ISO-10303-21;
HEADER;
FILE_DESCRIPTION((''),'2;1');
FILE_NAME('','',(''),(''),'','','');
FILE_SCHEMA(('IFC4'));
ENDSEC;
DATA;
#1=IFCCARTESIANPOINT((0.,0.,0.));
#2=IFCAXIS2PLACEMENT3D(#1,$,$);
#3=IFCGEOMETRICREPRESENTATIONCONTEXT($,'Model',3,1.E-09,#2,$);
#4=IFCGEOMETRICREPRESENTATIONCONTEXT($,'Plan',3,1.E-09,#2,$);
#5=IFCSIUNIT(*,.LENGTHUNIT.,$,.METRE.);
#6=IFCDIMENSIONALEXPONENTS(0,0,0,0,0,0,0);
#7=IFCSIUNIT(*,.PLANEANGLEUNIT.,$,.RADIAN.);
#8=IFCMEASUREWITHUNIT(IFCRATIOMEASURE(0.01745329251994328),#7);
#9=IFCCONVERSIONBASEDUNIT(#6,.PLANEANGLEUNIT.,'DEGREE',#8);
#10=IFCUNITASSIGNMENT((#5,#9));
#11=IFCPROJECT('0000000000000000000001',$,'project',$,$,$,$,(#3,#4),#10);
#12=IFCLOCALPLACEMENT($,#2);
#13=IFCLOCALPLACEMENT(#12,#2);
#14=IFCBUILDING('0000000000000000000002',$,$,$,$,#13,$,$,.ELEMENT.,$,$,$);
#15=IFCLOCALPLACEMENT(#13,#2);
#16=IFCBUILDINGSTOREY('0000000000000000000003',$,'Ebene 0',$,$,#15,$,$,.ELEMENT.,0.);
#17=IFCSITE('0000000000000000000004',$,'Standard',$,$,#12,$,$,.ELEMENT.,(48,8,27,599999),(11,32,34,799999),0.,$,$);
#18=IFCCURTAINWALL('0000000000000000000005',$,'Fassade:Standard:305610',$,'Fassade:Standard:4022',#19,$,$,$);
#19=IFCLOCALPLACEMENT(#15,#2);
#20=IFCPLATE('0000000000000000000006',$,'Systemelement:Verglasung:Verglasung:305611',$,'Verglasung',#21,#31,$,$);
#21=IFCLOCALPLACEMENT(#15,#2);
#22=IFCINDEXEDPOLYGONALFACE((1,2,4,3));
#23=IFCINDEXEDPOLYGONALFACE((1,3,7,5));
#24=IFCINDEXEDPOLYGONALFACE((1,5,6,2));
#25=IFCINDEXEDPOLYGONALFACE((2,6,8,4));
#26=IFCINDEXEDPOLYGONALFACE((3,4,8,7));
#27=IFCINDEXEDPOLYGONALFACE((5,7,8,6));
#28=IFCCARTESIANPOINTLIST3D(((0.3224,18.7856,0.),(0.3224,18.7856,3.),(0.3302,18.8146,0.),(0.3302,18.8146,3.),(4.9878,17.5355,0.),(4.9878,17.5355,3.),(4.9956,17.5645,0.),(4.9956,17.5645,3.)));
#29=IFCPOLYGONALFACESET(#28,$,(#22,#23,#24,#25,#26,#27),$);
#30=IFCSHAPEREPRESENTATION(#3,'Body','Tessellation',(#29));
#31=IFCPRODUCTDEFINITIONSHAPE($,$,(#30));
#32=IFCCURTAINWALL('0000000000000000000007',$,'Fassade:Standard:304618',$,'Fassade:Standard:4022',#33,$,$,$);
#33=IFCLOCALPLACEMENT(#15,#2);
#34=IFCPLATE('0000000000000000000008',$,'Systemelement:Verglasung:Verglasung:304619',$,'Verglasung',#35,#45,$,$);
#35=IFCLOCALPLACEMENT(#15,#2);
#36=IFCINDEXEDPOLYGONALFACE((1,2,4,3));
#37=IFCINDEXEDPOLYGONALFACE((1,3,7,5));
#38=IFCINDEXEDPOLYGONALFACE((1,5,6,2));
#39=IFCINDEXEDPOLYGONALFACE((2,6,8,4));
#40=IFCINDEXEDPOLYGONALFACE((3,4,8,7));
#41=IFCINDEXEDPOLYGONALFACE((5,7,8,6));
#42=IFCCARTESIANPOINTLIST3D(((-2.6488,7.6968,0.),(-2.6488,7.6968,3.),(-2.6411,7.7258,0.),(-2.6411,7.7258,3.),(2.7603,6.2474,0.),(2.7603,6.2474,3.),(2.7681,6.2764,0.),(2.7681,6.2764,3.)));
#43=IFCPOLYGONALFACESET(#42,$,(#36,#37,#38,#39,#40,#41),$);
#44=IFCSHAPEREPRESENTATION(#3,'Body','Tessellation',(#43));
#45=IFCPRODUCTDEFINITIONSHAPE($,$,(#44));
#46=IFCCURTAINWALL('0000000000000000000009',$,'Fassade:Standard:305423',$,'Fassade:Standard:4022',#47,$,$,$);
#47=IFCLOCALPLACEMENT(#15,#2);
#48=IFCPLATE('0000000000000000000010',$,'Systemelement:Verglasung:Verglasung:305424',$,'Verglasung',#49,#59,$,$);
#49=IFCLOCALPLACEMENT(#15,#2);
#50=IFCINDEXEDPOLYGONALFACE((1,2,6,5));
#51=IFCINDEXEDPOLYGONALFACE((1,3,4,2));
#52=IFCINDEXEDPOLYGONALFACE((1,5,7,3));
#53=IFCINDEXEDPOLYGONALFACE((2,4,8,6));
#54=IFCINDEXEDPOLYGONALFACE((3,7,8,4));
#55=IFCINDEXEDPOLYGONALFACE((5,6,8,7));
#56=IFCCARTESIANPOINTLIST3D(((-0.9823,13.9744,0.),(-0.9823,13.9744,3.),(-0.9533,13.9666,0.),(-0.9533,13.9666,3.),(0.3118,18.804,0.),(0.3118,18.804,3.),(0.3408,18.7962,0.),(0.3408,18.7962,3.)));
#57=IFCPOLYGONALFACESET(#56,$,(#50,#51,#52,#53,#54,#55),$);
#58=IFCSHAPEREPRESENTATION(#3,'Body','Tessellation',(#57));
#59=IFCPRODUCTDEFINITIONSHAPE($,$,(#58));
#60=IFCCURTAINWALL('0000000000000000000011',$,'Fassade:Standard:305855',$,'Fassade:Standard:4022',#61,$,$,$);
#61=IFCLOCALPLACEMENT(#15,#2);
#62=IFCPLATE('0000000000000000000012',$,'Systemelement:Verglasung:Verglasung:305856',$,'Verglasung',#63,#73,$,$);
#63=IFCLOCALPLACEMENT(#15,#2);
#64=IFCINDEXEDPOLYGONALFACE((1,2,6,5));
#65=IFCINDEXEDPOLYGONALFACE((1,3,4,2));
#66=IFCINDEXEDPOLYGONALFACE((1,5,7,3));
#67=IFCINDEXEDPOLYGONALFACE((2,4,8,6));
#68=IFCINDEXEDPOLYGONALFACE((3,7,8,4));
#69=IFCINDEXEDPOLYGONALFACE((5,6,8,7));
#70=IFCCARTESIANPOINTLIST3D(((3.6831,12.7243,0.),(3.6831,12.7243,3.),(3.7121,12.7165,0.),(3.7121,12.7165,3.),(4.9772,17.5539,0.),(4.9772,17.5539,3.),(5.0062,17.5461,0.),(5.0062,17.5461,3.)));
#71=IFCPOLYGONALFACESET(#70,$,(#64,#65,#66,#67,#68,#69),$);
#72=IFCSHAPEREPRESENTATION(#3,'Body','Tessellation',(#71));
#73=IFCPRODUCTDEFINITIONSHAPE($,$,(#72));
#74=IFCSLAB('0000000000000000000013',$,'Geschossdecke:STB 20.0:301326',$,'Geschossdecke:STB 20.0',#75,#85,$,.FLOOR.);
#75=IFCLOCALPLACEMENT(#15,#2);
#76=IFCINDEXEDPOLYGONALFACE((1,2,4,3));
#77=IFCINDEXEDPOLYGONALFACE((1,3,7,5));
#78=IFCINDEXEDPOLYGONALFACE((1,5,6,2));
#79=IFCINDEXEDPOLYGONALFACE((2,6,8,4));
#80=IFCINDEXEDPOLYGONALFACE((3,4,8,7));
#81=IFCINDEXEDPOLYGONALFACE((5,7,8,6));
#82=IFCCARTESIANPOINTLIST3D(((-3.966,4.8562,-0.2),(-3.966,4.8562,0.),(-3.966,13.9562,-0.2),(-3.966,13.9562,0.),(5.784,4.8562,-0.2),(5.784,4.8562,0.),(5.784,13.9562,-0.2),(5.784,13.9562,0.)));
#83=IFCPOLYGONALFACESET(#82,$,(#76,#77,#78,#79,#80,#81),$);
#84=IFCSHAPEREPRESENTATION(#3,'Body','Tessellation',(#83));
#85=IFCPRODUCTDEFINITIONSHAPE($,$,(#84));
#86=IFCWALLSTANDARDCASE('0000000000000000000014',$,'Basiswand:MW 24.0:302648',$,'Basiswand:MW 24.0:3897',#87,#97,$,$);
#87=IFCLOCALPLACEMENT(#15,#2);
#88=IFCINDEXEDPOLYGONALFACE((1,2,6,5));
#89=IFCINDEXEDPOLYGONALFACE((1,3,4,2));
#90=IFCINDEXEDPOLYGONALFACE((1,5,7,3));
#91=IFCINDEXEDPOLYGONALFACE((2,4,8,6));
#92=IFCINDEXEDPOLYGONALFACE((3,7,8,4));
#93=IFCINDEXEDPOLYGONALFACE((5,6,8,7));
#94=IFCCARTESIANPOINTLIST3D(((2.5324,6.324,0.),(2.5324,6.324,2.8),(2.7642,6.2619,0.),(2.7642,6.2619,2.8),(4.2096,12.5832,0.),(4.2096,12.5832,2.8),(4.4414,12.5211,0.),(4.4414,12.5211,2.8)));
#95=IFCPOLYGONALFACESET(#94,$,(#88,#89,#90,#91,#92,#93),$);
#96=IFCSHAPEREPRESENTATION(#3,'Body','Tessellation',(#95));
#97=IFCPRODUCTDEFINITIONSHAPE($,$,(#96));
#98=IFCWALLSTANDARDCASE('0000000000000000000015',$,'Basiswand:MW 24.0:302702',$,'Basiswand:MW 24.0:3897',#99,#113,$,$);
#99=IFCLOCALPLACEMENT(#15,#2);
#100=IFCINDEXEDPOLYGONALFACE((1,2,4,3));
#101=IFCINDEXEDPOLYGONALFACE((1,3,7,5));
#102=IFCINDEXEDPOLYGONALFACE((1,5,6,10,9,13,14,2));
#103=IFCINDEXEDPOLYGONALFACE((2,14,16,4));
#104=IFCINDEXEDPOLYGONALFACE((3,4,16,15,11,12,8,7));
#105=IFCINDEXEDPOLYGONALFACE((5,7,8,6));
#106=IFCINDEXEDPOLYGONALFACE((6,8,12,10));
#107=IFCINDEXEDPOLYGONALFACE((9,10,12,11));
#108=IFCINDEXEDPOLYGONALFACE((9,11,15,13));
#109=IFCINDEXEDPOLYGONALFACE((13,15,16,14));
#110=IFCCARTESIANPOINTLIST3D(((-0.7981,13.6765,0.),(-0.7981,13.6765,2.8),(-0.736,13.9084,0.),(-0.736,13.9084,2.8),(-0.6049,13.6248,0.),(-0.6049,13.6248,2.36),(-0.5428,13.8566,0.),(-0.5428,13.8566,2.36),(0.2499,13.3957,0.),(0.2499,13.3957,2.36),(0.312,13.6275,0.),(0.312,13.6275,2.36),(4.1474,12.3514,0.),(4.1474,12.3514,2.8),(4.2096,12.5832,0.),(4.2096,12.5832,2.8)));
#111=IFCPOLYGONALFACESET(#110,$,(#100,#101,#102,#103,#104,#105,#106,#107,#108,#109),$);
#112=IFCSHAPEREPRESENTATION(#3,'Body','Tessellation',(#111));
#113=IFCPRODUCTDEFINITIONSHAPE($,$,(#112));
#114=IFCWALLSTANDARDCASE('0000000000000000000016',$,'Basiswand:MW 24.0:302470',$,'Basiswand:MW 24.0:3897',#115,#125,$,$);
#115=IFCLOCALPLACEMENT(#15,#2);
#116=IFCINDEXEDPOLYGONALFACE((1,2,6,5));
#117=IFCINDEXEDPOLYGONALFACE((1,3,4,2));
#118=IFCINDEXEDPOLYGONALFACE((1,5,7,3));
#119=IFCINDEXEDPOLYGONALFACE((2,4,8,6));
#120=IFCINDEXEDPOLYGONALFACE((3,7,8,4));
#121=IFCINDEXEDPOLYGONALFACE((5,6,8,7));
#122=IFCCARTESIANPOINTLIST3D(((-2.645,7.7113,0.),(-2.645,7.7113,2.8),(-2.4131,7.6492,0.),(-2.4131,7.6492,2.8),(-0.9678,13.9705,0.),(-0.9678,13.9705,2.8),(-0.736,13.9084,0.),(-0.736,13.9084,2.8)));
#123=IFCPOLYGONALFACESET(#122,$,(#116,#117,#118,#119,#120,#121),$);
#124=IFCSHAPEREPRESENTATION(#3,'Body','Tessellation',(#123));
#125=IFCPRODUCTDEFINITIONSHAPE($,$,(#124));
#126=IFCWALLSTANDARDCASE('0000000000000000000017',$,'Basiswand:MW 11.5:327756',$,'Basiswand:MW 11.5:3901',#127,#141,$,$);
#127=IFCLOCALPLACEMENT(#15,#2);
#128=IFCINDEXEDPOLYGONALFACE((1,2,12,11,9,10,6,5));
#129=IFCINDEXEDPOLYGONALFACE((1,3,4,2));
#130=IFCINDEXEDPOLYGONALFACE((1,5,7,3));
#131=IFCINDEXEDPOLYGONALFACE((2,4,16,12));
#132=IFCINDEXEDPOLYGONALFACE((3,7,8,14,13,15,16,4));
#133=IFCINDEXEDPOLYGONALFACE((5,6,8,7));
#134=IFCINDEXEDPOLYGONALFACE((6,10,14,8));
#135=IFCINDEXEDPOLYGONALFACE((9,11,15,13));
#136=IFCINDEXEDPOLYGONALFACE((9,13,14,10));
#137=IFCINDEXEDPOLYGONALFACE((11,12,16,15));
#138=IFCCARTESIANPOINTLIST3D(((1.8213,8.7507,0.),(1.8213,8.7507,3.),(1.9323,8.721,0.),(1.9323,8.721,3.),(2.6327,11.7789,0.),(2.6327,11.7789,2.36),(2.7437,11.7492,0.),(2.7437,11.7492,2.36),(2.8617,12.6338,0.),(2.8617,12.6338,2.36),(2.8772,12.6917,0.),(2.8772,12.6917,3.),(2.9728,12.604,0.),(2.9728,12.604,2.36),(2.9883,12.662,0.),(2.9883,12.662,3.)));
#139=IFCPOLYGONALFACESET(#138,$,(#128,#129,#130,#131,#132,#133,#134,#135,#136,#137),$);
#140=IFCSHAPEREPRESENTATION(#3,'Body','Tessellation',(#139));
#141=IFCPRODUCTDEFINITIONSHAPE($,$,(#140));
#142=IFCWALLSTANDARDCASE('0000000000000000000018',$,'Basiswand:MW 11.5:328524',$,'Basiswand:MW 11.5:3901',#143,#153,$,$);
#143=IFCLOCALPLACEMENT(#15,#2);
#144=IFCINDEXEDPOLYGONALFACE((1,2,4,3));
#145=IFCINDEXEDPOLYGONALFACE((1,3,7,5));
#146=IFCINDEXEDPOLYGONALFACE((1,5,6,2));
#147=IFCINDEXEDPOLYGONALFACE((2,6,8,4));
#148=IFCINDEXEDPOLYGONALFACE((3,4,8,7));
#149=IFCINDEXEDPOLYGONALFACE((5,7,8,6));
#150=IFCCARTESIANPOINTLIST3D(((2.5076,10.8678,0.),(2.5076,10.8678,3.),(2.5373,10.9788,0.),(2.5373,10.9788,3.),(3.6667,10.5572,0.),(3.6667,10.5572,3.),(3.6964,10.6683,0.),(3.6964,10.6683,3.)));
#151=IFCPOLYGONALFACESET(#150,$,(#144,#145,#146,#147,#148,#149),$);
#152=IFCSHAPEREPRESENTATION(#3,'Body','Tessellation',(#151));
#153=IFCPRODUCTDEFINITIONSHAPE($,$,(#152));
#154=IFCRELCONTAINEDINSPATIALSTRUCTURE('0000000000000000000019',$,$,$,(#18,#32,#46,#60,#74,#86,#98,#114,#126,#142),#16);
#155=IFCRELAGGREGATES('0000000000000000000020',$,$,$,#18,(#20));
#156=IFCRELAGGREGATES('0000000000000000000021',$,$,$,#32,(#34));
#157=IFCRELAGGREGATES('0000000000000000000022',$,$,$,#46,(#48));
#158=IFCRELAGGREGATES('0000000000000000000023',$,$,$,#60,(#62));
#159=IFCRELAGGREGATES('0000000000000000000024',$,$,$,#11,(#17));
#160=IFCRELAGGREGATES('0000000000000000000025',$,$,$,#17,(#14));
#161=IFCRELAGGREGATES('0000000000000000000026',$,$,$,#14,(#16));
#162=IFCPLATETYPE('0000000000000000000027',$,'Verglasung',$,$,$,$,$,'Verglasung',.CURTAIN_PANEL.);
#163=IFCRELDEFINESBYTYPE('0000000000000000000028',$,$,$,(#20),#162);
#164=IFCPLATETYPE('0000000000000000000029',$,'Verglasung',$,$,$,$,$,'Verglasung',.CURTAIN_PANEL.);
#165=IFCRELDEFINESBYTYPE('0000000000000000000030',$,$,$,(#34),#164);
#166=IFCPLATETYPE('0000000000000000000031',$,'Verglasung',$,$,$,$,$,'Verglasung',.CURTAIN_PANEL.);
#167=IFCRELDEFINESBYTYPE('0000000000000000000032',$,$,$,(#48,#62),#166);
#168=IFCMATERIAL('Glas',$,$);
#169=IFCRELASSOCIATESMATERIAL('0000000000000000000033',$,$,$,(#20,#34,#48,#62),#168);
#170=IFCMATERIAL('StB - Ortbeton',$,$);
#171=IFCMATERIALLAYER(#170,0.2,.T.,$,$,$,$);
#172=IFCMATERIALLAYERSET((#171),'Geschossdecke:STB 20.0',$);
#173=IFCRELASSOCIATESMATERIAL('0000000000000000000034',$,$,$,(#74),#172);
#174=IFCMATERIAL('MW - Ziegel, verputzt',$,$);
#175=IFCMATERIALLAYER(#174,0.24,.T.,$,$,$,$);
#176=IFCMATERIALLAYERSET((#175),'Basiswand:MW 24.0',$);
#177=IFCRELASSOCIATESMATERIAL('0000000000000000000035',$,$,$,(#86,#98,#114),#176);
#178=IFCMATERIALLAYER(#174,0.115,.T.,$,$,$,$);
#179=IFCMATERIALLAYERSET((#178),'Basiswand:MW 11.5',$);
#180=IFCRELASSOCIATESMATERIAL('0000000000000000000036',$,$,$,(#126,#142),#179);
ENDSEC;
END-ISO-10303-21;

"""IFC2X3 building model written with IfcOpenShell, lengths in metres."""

from ifc_helpers import new_model, entity, si_unit, converted_unit, frame, frame_2d, origin, origin_2d_with_axis, place, context, project, spatial, polyline, rectangle, extrude, clip, bounded_halfspace, source, transform, mapped, material, layer, layer_set, layer_usage, type_object, type_shapes, element, aggregate, save


model = new_model("IFC2X3")

# Units and contexts
model_context = context("Model", 3, precision=1e-09, world=origin())
plan_context = context("Plan", 3, precision=1e-09, world=origin())
ifc_project = project(units=[si_unit("LENGTHUNIT", "METRE"), converted_unit("PLANEANGLEUNIT", "DEGREE", entity("IfcRatioMeasure", 0.01745329251994328), si_unit("PLANEANGLEUNIT", "RADIAN"), dimensions=[0, 0, 0, 0, 0, 0, 0])], contexts=[model_context, plan_context])

# Site, building, storey
site_placement = place(None, origin())
site = spatial("IfcSite", under=ifc_project, at=site_placement, Name="Standard", CompositionType="ELEMENT", RefLatitude=(48, 8, 27, 599999), RefLongitude=(11, 32, 34, 799999), RefElevation=0.0)
building_placement = place(site_placement, origin())
building = spatial("IfcBuilding", under=site, at=building_placement, CompositionType="ELEMENT")
storey_placement = place(building_placement, origin())
storey = spatial("IfcBuildingStorey", under=building, at=storey_placement, Name="Ebene 0", CompositionType="ELEMENT", Elevation=0.0)

# Curtain walls, plates
curtain_wall_1_placement = place(storey_placement, origin())
curtain_wall_1 = element("IfcCurtainWall", 1, at=curtain_wall_1_placement, inside=storey, Name="Fassade:Standard:305610", ObjectType="Fassade:Standard:4022")
ifc_material_1 = material(Name="Glas")
plate_type_1 = type_object("IfcPlateType", Name="Verglasung", ElementType="Verglasung", PredefinedType="CURTAIN_PANEL")
shared_shape_1 = source(origin(), model_context, "Body", "SweptSolid", [
    extrude(rectangle(XDim=0.03, YDim=4.83, at=origin_2d_with_axis()), frame((0.0, 0.0, 0.0), z_axis=(0.0, 0.0, 1.0), x_axis=(0.0, 1.0, 0.0)), (0.0, 0.0, 1.0), 3.0),
])
type_shapes(plate_type_1, [shared_shape_1])
plate_1_placement = place(storey_placement, frame((2.659, 18.1751, 0.0), z_axis=(0.0, 0.0, 1.0), x_axis=(0.965926, -0.258819, 0.0)))
plate_1 = element("IfcPlate", 2, at=plate_1_placement, type_object=plate_type_1, material=ifc_material_1, Name="Systemelement:Verglasung:Verglasung:305611", ObjectType="Verglasung", context=model_context, shape_type="MappedRepresentation", body=[
    mapped(shared_shape_1, transform((0.0, 0.0, 0.0), scale=1.0)),
])
aggregate(curtain_wall_1, [plate_1])
curtain_wall_2_placement = place(storey_placement, origin())
curtain_wall_2 = element("IfcCurtainWall", 3, at=curtain_wall_2_placement, inside=storey, Name="Fassade:Standard:304618", ObjectType="Fassade:Standard:4022")
plate_type_2 = type_object("IfcPlateType", Name="Verglasung", ElementType="Verglasung", PredefinedType="CURTAIN_PANEL")
shared_shape_2 = source(origin(), model_context, "Body", "SweptSolid", [
    extrude(rectangle(XDim=0.03, YDim=5.6, at=origin_2d_with_axis()), frame((0.0, 0.0, 0.0), z_axis=(0.0, 0.0, 1.0), x_axis=(0.0, 1.0, 0.0)), (0.0, 0.0, 1.0), 3.0),
])
type_shapes(plate_type_2, [shared_shape_2])
plate_2_placement = place(storey_placement, frame((0.0596, 6.9866, 0.0), z_axis=(0.0, 0.0, 1.0), x_axis=(0.965926, -0.258819, 0.0)))
plate_2 = element("IfcPlate", 4, at=plate_2_placement, type_object=plate_type_2, material=ifc_material_1, Name="Systemelement:Verglasung:Verglasung:304619", ObjectType="Verglasung", context=model_context, shape_type="MappedRepresentation", body=[
    mapped(shared_shape_2, transform((0.0, 0.0, 0.0), scale=1.0)),
])
aggregate(curtain_wall_2, [plate_2])
curtain_wall_3_placement = place(storey_placement, origin())
curtain_wall_3 = element("IfcCurtainWall", 5, at=curtain_wall_3_placement, inside=storey, Name="Fassade:Standard:305423", ObjectType="Fassade:Standard:4022")
plate_type_3 = type_object("IfcPlateType", Name="Verglasung", ElementType="Verglasung", PredefinedType="CURTAIN_PANEL")
shared_shape_3 = source(origin(), model_context, "Body", "SweptSolid", [
    extrude(rectangle(XDim=0.03, YDim=5.0, at=origin_2d_with_axis()), frame((0.0, 0.0, 0.0), z_axis=(0.0, 0.0, 1.0), x_axis=(0.0, 1.0, 0.0)), (0.0, 0.0, 1.0), 3.0),
])
type_shapes(plate_type_3, [shared_shape_3])
plate_3_placement = place(storey_placement, frame((-0.3208, 16.3853, 0.0), z_axis=(0.0, 0.0, 1.0), x_axis=(0.258819, 0.965926, 0.0)))
plate_3 = element("IfcPlate", 6, at=plate_3_placement, type_object=plate_type_3, material=ifc_material_1, Name="Systemelement:Verglasung:Verglasung:305424", ObjectType="Verglasung", context=model_context, shape_type="MappedRepresentation", body=[
    mapped(shared_shape_3, transform((0.0, 0.0, 0.0), scale=1.0)),
])
aggregate(curtain_wall_3, [plate_3])
curtain_wall_4_placement = place(storey_placement, origin())
curtain_wall_4 = element("IfcCurtainWall", 7, at=curtain_wall_4_placement, inside=storey, Name="Fassade:Standard:305855", ObjectType="Fassade:Standard:4022")
plate_4_placement = place(storey_placement, frame((4.3447, 15.1352, 0.0), z_axis=(0.0, 0.0, 1.0), x_axis=(-0.258819, -0.965926, 0.0)))
plate_4 = element("IfcPlate", 8, at=plate_4_placement, type_object=plate_type_3, material=ifc_material_1, Name="Systemelement:Verglasung:Verglasung:305856", ObjectType="Verglasung", context=model_context, shape_type="MappedRepresentation", body=[
    mapped(shared_shape_3, transform((0.0, 0.0, 0.0), scale=1.0)),
])
aggregate(curtain_wall_4, [plate_4])

# Slab
ifc_material_2 = material(Name="StB - Ortbeton")
ifc_layer_1 = layer(ifc_material_2, 0.2, ventilated=True)
ifc_layer_set_1 = layer_set([ifc_layer_1], Name="Geschossdecke:STB 20.0")
ifc_layer_usage_1 = layer_usage(ifc_layer_set_1, "AXIS3", "POSITIVE", 0.0)
slab_1_placement = place(storey_placement, frame((-3.966, 4.8562, -0.2)))
element("IfcSlab", 9, at=slab_1_placement, inside=storey, material=ifc_layer_usage_1, Name="Geschossdecke:STB 20.0:301326", ObjectType="Geschossdecke:STB 20.0", PredefinedType="FLOOR", context=model_context, shape_type="SweptSolid", body=[
    extrude(rectangle(XDim=9.1, YDim=9.75, at=frame_2d((0.0, 0.0), x_axis=(0.0, -1.0))), frame((4.875, 4.55, 0.2), z_axis=(0.0, 0.0, -1.0), x_axis=(-1.0, 0.0, 0.0)), (0.0, 0.0, 1.0), 0.2),
])

# Wall
ifc_material_3 = material(Name="MW - Ziegel, verputzt")
ifc_layer_2 = layer(ifc_material_3, 0.24, ventilated=True)
ifc_layer_set_2 = layer_set([ifc_layer_2], Name="Basiswand:MW 24.0")
ifc_layer_usage_2 = layer_usage(ifc_layer_set_2, "AXIS2", "NEGATIVE", 0.12)
wall_1_placement = place(storey_placement, frame((2.6483, 6.2929, 0.0), z_axis=(0.0, 0.0, 1.0), x_axis=(0.258819, 0.965926, 0.0)))
element("IfcWallStandardCase", 10, at=wall_1_placement, inside=storey, material=ifc_layer_usage_2, Name="Basiswand:MW 24.0:302648", ObjectType="Basiswand:MW 24.0:3897", context=model_context, shape_type="Clipping", body=[
    clip(extrude(rectangle(XDim=6.48, YDim=0.24, at=frame_2d((3.24, 0.0), x_axis=(-1.0, 0.0))), origin(), (0.0, 0.0, 1.0), 2.8), bounded_halfspace(frame((0.0, -0.12, 2.8), z_axis=(0.0, 0.0, -1.0), x_axis=(0.258819, -0.965926, 0.0)), True, frame((0.0, -0.12, 2.8)), polyline([(0.0, 0.0), (6.48, 0.0), (6.48, 0.24), (6.24, 0.24), (0.0, 0.24), (0.0, 0.0)]))),
])

# Wall, opening
ifc_layer_usage_3 = layer_usage(ifc_layer_set_2, "AXIS2", "NEGATIVE", 0.12)
wall_2_placement = place(storey_placement, frame((4.1785, 12.4673, 0.0), z_axis=(0.0, 0.0, 1.0), x_axis=(-0.965926, 0.258819, 0.0)))
wall_2 = element("IfcWallStandardCase", 11, at=wall_2_placement, inside=storey, material=ifc_layer_usage_3, Name="Basiswand:MW 24.0:302702", ObjectType="Basiswand:MW 24.0:3897", context=model_context, shape_type="Clipping", body=[
    clip(extrude(rectangle(XDim=5.12, YDim=0.24, at=frame_2d((2.56, 0.0), x_axis=(-1.0, 0.0))), origin(), (0.0, 0.0, 1.0), 2.8), bounded_halfspace(frame((5.12, 0.12, 2.8), z_axis=(0.0, 0.0, -1.0), x_axis=(-0.965926, -0.258819, 0.0)), True, frame((5.12, 0.12, 2.8)), polyline([(0.0, 0.0), (-5.12, 0.0), (-5.12, -0.24), (-2.9061, -0.24), (0.0, -0.24), (0.0, 0.0)]))),
])
opening_1_placement = place(wall_2_placement, frame((4.92, 0.12, 0.0)))
element("IfcOpeningElement", 12, at=opening_1_placement, cuts=wall_2, ObjectType="Opening", context=model_context, shape_type="SweptSolid", body=[
    extrude(rectangle(XDim=2.36, YDim=0.885, at=frame_2d((1.18, 0.4425), x_axis=(1.0, 0.0))), frame((0.0, 0.0, 0.0), z_axis=(0.0, -1.0, 0.0), x_axis=(0.0, 0.0, 1.0)), (0.0, 0.0, 1.0), 0.24),
])

# Wall
ifc_layer_usage_4 = layer_usage(ifc_layer_set_2, "AXIS2", "NEGATIVE", 0.12)
wall_3_placement = place(storey_placement, frame((-0.8519, 13.9394, 0.0), z_axis=(0.0, 0.0, 1.0), x_axis=(-0.258819, -0.965926, 0.0)))
element("IfcWallStandardCase", 13, at=wall_3_placement, inside=storey, material=ifc_layer_usage_4, Name="Basiswand:MW 24.0:302470", ObjectType="Basiswand:MW 24.0:3897", context=model_context, shape_type="Clipping", body=[
    clip(extrude(rectangle(XDim=6.48, YDim=0.24, at=frame_2d((3.24, 0.0), x_axis=(-1.0, 0.0))), origin(), (0.0, 0.0, 1.0), 2.8), bounded_halfspace(frame((0.0, -0.12, 2.8), z_axis=(0.0, 0.0, -1.0), x_axis=(-0.258819, 0.965926, 0.0)), True, frame((0.0, -0.12, 2.8)), polyline([(0.0, 0.0), (6.48, 0.0), (6.48, 0.24), (0.24, 0.24), (0.0, 0.24), (0.0, 0.0)]))),
])

# Wall, opening
ifc_layer_3 = layer(ifc_material_3, 0.115, ventilated=True)
ifc_layer_set_3 = layer_set([ifc_layer_3], Name="Basiswand:MW 11.5")
ifc_layer_usage_5 = layer_usage(ifc_layer_set_3, "AXIS2", "POSITIVE", -0.0575)
wall_4_placement = place(storey_placement, frame((2.9328, 12.6768, 0.0), z_axis=(0.0, 0.0, 1.0), x_axis=(-0.258819, -0.965926, 0.0)))
wall_4 = element("IfcWallStandardCase", 14, at=wall_4_placement, inside=storey, material=ifc_layer_usage_5, Name="Basiswand:MW 11.5:327756", ObjectType="Basiswand:MW 11.5:3901", context=model_context, shape_type="SweptSolid", body=[
    extrude(rectangle(XDim=4.08, YDim=0.115, at=frame_2d((2.04, 0.0), x_axis=(-1.0, 0.0))), origin(), (0.0, 0.0, 1.0), 3.0),
])
opening_2_placement = place(wall_4_placement, frame((0.06, -0.0575, 0.0)))
element("IfcOpeningElement", 15, at=opening_2_placement, cuts=wall_4, ObjectType="Opening", context=model_context, shape_type="SweptSolid", body=[
    extrude(rectangle(XDim=2.36, YDim=0.885, at=frame_2d((1.18, 0.4425), x_axis=(1.0, 0.0))), frame((0.0, 0.0, 0.0), z_axis=(0.0, 1.0, 0.0), x_axis=(0.0, 0.0, 1.0)), (0.0, 0.0, 1.0), 0.115),
])

# Wall
ifc_layer_usage_6 = layer_usage(ifc_layer_set_3, "AXIS2", "NEGATIVE", 0.0575)
wall_5_placement = place(storey_placement, frame((2.5225, 10.9233, 0.0), z_axis=(0.0, 0.0, 1.0), x_axis=(0.965926, -0.258819, 0.0)))
element("IfcWallStandardCase", 16, at=wall_5_placement, inside=storey, material=ifc_layer_usage_6, Name="Basiswand:MW 11.5:328524", ObjectType="Basiswand:MW 11.5:3901", context=model_context, shape_type="SweptSolid", body=[
    extrude(rectangle(XDim=1.2, YDim=0.115, at=frame_2d((0.6, 0.0), x_axis=(-1.0, 0.0))), origin(), (0.0, 0.0, 1.0), 3.0),
])

save(model, "model.ifc")
